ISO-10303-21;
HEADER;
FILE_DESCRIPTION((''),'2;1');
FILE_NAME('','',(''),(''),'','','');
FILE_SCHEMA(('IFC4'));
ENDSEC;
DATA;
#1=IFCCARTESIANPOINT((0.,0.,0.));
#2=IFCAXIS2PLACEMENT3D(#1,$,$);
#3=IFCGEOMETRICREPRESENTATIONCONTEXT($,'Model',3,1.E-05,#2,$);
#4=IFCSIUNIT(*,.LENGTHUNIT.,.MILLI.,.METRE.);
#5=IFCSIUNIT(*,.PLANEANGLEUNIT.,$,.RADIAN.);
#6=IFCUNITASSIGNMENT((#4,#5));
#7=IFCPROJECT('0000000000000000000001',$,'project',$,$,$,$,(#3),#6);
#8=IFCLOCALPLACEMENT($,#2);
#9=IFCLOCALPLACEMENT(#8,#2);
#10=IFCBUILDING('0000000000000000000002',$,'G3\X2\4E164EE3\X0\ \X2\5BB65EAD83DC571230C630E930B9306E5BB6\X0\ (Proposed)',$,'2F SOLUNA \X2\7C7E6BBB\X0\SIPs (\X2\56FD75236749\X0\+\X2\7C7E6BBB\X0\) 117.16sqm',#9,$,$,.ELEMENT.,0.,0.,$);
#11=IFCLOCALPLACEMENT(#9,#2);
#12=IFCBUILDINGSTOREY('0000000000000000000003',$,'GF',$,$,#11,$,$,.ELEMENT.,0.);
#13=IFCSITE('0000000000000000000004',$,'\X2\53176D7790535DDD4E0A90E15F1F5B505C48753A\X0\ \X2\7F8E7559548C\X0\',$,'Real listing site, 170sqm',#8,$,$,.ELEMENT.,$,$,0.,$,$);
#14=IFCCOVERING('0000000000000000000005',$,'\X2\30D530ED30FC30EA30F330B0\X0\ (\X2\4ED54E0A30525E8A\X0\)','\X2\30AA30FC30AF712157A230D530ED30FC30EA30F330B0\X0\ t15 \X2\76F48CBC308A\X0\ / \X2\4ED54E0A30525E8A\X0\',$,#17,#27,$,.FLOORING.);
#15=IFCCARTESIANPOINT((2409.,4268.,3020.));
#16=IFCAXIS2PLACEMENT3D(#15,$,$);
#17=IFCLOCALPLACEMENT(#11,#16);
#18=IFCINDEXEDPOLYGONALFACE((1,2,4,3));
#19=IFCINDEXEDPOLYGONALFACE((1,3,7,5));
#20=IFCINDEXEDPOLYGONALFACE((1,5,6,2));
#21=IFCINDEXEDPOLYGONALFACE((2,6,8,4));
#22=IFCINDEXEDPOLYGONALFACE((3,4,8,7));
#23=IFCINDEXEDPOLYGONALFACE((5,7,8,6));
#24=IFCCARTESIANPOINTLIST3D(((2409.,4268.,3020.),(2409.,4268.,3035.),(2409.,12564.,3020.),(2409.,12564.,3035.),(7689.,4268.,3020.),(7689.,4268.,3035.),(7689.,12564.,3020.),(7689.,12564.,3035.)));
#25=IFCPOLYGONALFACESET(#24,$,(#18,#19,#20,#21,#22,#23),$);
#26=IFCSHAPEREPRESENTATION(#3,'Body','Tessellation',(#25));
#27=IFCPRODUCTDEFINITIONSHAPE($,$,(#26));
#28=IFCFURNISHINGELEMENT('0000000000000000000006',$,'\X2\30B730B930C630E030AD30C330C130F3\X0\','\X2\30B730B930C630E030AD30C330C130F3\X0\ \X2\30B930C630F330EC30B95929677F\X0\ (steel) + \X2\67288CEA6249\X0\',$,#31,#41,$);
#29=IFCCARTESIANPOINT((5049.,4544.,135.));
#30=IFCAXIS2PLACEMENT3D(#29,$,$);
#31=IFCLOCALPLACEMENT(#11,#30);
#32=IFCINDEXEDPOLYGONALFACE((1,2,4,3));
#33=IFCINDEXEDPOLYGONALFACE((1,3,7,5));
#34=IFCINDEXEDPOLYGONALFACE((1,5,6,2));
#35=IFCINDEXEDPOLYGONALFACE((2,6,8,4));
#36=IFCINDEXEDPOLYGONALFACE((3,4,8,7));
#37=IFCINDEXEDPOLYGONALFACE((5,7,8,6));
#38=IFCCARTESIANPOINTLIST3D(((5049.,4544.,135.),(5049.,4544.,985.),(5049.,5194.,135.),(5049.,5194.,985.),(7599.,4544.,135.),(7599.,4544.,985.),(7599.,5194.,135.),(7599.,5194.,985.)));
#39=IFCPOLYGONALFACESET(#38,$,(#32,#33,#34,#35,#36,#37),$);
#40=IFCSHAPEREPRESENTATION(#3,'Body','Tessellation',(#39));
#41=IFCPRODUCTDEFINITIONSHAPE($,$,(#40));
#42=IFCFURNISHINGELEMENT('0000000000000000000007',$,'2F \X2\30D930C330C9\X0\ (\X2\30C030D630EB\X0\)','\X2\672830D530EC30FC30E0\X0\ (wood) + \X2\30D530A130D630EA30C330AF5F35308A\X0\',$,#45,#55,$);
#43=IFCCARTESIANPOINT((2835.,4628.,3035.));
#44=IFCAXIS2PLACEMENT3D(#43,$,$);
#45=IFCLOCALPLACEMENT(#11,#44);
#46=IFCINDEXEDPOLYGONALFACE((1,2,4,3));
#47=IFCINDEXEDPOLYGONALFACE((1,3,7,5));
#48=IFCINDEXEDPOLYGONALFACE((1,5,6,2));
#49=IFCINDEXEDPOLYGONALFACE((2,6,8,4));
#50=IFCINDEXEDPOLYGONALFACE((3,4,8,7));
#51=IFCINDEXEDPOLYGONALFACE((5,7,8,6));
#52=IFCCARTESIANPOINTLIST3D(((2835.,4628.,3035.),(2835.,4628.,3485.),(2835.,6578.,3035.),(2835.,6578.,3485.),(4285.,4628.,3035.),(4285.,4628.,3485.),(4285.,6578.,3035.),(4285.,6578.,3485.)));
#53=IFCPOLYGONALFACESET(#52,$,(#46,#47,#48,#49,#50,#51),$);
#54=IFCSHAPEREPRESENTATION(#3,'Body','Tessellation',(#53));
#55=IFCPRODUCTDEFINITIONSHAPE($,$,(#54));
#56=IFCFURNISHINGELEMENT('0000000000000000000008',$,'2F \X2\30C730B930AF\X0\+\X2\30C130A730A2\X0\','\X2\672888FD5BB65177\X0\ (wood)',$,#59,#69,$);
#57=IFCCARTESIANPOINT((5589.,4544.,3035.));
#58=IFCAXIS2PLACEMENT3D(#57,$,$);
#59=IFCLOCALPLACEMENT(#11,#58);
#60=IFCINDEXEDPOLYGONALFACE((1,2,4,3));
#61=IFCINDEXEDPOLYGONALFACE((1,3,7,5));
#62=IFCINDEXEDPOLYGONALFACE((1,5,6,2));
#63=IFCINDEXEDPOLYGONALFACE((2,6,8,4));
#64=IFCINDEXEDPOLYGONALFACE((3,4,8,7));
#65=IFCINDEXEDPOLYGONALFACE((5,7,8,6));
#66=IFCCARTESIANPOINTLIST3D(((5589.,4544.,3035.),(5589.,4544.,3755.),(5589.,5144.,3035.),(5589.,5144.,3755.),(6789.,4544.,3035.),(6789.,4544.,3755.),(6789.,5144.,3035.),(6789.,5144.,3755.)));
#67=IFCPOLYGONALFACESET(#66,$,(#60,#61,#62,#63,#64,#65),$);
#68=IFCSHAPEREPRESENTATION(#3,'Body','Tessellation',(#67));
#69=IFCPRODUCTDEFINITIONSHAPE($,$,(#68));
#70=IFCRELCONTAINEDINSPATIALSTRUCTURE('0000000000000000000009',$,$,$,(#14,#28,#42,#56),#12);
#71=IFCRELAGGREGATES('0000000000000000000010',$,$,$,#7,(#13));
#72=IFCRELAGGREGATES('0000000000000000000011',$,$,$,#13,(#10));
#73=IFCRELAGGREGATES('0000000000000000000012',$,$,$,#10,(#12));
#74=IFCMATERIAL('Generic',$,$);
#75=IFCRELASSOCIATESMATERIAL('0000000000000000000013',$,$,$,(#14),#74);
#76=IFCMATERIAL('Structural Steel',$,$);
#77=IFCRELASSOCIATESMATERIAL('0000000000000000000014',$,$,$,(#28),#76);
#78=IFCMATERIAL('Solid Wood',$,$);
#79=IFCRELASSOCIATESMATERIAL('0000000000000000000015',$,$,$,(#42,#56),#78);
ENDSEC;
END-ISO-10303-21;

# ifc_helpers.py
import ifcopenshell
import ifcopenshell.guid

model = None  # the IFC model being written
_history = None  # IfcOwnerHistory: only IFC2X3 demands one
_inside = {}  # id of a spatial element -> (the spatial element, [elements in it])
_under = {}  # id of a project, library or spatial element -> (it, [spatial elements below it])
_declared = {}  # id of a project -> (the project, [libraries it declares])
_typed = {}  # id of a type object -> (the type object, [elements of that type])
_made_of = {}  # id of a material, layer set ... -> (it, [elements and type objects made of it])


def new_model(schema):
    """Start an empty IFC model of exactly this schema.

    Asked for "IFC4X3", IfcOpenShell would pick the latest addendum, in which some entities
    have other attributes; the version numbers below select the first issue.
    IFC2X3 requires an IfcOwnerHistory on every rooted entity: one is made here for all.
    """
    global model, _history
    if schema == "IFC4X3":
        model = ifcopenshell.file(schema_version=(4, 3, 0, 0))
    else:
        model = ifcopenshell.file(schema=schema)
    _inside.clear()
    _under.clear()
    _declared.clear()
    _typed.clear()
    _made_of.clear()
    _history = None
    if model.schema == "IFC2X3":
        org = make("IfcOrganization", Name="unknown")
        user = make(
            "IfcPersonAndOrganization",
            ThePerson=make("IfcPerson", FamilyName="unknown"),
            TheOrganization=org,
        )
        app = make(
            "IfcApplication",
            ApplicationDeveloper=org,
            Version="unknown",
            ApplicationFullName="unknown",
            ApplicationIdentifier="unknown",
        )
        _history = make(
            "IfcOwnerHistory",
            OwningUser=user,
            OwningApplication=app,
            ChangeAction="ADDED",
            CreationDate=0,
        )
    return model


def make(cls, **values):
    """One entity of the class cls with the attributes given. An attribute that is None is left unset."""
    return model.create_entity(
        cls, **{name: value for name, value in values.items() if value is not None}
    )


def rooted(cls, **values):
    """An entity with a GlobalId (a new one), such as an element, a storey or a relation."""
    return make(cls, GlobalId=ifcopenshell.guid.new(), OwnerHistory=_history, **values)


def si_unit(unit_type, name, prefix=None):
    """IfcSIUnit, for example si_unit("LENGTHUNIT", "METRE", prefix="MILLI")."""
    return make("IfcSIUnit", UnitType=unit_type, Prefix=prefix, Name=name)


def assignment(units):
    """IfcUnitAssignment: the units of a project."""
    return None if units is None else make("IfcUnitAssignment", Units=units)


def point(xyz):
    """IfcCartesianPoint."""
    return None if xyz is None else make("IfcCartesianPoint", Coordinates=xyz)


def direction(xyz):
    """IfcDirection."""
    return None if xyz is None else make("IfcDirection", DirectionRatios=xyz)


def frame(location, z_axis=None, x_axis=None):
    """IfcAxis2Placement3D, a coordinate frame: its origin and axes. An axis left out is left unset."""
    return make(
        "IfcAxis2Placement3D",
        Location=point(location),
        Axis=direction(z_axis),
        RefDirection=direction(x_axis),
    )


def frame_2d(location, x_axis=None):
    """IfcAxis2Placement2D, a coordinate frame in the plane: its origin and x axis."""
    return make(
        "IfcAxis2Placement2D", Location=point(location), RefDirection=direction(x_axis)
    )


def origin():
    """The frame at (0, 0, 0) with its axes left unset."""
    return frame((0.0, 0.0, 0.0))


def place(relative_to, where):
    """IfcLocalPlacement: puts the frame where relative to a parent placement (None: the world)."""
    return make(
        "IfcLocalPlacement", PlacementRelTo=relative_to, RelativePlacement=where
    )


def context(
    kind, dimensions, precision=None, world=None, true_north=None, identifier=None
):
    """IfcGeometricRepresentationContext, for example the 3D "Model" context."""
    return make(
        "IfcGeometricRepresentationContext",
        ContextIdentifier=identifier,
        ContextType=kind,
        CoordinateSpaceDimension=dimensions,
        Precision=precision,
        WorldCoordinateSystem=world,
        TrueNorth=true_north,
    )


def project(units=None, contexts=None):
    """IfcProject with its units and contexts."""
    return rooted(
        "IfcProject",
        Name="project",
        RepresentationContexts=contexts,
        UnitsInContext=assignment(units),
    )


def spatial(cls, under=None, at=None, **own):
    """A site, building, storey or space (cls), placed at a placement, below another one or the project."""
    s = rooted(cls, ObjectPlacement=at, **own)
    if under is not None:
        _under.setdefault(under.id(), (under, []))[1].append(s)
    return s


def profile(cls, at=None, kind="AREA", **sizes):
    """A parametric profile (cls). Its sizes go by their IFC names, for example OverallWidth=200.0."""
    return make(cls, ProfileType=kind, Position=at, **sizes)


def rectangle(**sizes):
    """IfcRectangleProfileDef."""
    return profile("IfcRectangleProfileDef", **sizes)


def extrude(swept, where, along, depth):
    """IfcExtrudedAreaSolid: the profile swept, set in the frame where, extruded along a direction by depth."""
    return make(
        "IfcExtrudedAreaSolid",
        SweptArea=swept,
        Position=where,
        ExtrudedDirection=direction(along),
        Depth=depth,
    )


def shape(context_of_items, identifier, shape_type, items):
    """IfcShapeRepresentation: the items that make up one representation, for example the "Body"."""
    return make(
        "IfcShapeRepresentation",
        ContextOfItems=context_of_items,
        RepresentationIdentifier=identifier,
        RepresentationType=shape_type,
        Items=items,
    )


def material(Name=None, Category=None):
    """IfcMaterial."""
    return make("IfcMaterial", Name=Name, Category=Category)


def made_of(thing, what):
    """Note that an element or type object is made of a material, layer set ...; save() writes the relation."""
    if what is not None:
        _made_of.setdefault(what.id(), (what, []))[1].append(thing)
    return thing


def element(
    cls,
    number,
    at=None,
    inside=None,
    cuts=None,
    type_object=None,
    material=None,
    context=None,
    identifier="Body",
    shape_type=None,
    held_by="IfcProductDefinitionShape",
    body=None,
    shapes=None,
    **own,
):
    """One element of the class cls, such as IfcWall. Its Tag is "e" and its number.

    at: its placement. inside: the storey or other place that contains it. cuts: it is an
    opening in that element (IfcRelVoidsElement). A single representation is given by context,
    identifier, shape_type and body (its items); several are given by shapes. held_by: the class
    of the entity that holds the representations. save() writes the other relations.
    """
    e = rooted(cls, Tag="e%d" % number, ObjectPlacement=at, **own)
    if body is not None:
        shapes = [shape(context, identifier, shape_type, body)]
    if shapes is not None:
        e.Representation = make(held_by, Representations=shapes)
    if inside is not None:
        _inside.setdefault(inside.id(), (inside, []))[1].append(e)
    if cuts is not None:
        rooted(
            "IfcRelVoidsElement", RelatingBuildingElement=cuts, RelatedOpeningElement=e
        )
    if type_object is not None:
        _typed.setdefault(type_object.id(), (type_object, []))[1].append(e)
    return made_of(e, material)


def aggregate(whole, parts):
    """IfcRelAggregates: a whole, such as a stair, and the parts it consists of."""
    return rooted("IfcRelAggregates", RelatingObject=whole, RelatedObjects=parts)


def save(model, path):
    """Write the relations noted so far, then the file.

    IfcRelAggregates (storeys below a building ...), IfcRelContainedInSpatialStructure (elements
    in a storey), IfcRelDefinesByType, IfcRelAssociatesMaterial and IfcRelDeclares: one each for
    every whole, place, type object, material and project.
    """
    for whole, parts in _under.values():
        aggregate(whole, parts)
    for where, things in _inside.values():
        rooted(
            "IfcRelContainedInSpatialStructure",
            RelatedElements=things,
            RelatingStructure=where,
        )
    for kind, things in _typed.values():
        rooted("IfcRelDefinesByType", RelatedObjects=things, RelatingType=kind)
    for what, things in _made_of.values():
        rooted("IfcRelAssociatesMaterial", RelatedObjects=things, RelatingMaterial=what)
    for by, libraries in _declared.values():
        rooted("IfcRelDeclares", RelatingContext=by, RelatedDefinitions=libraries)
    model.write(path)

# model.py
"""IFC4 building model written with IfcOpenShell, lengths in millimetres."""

from ifc_helpers import new_model, si_unit, frame, frame_2d, origin, place, context, project, spatial, rectangle, extrude, material, element, save


model = new_model("IFC4")

# Units and contexts
model_context = context("Model", 3, precision=1e-05, world=origin())
ifc_project = project(units=[si_unit("LENGTHUNIT", "METRE", prefix="MILLI"), si_unit("PLANEANGLEUNIT", "RADIAN")], contexts=[model_context])

# Site, building, storey
site_placement = place(None, origin())
site = spatial("IfcSite", under=ifc_project, at=site_placement, Name="北海道川上郡弟子屈町 美留和", ObjectType="Real listing site, 170sqm", CompositionType="ELEMENT", RefElevation=0.0)
building_placement = place(site_placement, origin())
building = spatial("IfcBuilding", under=site, at=building_placement, Name="G3世代 家庭菜園テラスの家 (Proposed)", ObjectType="2F SOLUNA 籾殻SIPs (国産杉+籾殻) 117.16sqm", CompositionType="ELEMENT", ElevationOfRefHeight=0.0, ElevationOfTerrain=0.0)
storey_placement = place(building_placement, origin())
storey = spatial("IfcBuildingStorey", under=building, at=storey_placement, Name="GF", CompositionType="ELEMENT", Elevation=0.0)

# Shared definitions
ifc_material_1 = material(Name="Solid Wood")

# Shared definitions
ifc_material_2 = material(Name="Generic")

# Shared definitions
ifc_material_3 = material(Name="Structural Steel")

# Covering
covering_placement = place(storey_placement, frame((2409.0, 4268.0, 3020.0)))
element("IfcCovering", 1, at=covering_placement, inside=storey, material=ifc_material_2, Name="フローリング (仕上げ床)", Description="オーク無垢フローリング t15 直貼り / 仕上げ床", PredefinedType="FLOORING", context=model_context, shape_type="SweptSolid", body=[
    extrude(rectangle(XDim=5280.0, YDim=8296.0, at=frame_2d((2640.0, 4148.0))), frame((2409.0, 4268.0, 3020.0)), (0.0, 0.0, 1.0), 15.0),
])

# Furnishing elements
furnishing_1_placement = place(storey_placement, frame((5049.0, 4544.0, 135.0)))
element("IfcFurnishingElement", 2, at=furnishing_1_placement, inside=storey, material=ifc_material_3, Name="システムキッチン", Description="システムキッチン ステンレス天板 (steel) + 木質扉", context=model_context, shape_type="SweptSolid", body=[
    extrude(rectangle(XDim=2550.0, YDim=650.0, at=frame_2d((1275.0, 325.0))), frame((5049.0, 4544.0, 135.0)), (0.0, 0.0, 1.0), 850.0),
])
furnishing_2_placement = place(storey_placement, frame((2835.0, 4628.0, 3035.0)))
element("IfcFurnishingElement", 3, at=furnishing_2_placement, inside=storey, material=ifc_material_1, Name="2F ベッド (ダブル)", Description="木フレーム (wood) + ファブリック張り", context=model_context, shape_type="SweptSolid", body=[
    extrude(rectangle(XDim=1450.0, YDim=1950.0, at=frame_2d((725.0, 975.0))), frame((2835.0, 4628.0, 3035.0)), (0.0, 0.0, 1.0), 450.0),
])
furnishing_3_placement = place(storey_placement, frame((5589.0, 4544.0, 3035.0)))
element("IfcFurnishingElement", 4, at=furnishing_3_placement, inside=storey, material=ifc_material_1, Name="2F デスク+チェア", Description="木製家具 (wood)", context=model_context, shape_type="SweptSolid", body=[
    extrude(rectangle(XDim=1200.0, YDim=600.0, at=frame_2d((600.0, 300.0))), frame((5589.0, 4544.0, 3035.0)), (0.0, 0.0, 1.0), 720.0),
])

save(model, "model.ifc")
